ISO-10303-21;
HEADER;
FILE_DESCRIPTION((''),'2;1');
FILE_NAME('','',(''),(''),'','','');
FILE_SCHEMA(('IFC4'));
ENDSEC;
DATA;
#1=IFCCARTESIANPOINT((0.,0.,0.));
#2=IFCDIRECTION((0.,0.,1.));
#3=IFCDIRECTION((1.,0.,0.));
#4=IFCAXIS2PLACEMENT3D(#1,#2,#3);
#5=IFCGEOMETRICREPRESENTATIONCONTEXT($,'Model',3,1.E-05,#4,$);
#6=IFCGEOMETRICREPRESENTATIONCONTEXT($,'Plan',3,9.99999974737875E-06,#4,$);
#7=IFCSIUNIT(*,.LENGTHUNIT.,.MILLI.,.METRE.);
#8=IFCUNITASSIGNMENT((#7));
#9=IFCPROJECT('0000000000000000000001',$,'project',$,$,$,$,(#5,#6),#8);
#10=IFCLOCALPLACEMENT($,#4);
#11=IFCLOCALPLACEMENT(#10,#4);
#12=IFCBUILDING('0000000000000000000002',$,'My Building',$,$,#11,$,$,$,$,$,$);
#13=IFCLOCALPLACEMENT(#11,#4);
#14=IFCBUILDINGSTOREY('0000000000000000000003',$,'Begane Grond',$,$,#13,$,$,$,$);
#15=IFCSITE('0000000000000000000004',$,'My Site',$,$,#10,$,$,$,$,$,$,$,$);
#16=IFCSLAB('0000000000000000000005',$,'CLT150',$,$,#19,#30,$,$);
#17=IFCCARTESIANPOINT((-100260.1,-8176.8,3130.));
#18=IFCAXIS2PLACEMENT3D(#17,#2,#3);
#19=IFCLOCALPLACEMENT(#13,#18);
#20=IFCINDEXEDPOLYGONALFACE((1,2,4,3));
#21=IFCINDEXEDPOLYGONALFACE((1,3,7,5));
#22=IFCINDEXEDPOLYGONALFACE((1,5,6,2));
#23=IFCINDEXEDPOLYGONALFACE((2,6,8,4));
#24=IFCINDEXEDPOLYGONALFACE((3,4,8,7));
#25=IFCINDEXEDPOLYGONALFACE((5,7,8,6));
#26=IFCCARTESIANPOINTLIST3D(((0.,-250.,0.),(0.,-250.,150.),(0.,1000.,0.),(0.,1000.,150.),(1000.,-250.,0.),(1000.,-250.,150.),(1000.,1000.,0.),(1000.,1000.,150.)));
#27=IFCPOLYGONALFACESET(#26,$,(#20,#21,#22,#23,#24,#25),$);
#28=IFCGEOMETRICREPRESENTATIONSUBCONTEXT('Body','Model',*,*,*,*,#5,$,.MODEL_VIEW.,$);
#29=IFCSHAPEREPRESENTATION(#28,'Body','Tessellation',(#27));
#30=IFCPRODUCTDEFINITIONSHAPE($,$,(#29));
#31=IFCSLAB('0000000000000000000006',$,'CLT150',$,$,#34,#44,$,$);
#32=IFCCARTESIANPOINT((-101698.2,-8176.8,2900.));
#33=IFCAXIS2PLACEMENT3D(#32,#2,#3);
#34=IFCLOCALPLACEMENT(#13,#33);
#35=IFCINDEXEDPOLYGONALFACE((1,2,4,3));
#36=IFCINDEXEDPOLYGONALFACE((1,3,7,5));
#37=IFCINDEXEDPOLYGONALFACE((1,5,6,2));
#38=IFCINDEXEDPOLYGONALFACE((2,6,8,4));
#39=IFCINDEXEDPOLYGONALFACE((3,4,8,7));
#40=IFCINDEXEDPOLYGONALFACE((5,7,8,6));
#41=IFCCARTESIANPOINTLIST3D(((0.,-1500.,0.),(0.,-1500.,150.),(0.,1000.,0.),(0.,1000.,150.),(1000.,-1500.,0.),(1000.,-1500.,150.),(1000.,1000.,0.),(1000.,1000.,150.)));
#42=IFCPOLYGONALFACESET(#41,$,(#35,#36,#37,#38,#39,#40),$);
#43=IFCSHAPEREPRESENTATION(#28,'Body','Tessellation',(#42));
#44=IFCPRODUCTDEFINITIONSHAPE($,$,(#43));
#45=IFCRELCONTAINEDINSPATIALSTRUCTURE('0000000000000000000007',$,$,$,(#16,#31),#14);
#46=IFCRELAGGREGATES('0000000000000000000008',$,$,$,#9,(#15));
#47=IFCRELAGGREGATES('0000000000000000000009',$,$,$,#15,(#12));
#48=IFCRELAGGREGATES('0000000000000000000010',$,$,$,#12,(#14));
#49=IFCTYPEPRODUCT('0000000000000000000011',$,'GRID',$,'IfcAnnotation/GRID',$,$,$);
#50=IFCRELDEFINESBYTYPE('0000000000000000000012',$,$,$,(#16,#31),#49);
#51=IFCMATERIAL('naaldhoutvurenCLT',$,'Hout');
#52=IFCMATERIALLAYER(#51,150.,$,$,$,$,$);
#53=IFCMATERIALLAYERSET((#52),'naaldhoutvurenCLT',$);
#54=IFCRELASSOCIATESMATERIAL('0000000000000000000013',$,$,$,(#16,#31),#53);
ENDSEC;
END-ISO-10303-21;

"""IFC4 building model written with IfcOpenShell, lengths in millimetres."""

from ifc_helpers import new_model, si_unit, frame, origin_with_axes, place, context, subcontext, project, spatial, line, indexed_curve, outline, extrude, material, layer, layer_set, layer_usage, type_object, element, save


model = new_model("IFC4")

# Units and contexts
model_context = context("Model", 3, precision=1e-05, world=origin_with_axes())
plan_context = context("Plan", 3, precision=9.99999974737875e-06, world=origin_with_axes())
body_context = subcontext(model_context, "Body", "Model", "MODEL_VIEW")
ifc_project = project(units=[si_unit("LENGTHUNIT", "METRE", prefix="MILLI")], contexts=[model_context, plan_context])

# Site, building, storey
site_placement = place(None, frame((0.0, 0.0, 0.0), z_axis=(0.0, 0.0, 1.0), x_axis=(1.0, 0.0, 0.0)))
site = spatial("IfcSite", under=ifc_project, at=site_placement, Name="My Site")
building_placement = place(site_placement, origin_with_axes())
building = spatial("IfcBuilding", under=site, at=building_placement, Name="My Building")
storey_placement = place(building_placement, origin_with_axes())
storey = spatial("IfcBuildingStorey", under=building, at=storey_placement, Name="Begane Grond")

# Shared definitions
type_product = type_object("IfcTypeProduct", Name="GRID", ApplicableOccurrence="IfcAnnotation/GRID")

# Slabs
ifc_material_1 = material(Name="naaldhoutvurenCLT", Category="Hout")
ifc_layer_1 = layer(ifc_material_1, 150.0)
ifc_layer_set_1 = layer_set([ifc_layer_1], Name="naaldhoutvurenCLT")
ifc_layer_usage_1 = layer_usage(ifc_layer_set_1, "AXIS3", "POSITIVE", 0.0)
slab_1_placement = place(storey_placement, frame((-100260.1, -8176.8, 3130.0), z_axis=(0.0, 0.0, 1.0), x_axis=(1.0, 0.0, 0.0)))
element("IfcSlab", 1, at=slab_1_placement, inside=storey, type_object=type_product, material=ifc_layer_usage_1, Name="CLT150", context=body_context, shape_type="SweptSolid", body=[
    extrude(outline(indexed_curve([(1000.0, 1000.0), (1000.0, -250.0), (0.0, -250.0), (0.0, 1000.0)], segments=[line(4, 1), line(1, 2), line(2, 3), line(3, 4)], self_intersect=False)), None, (0.0, 0.0, 1.0), 150.0),
])
ifc_layer_usage_2 = layer_usage(ifc_layer_set_1, "AXIS3", "POSITIVE", 0.0)
slab_2_placement = place(storey_placement, frame((-101698.2, -8176.8, 2900.0), z_axis=(0.0, 0.0, 1.0), x_axis=(1.0, 0.0, 0.0)))
element("IfcSlab", 2, at=slab_2_placement, inside=storey, type_object=type_product, material=ifc_layer_usage_2, Name="CLT150", context=body_context, shape_type="SweptSolid", body=[
    extrude(outline(indexed_curve([(0.0, -1500.0), (1000.0, -1500.0), (1000.0, 1000.0), (0.0, 1000.0)], segments=[line(3, 2), line(2, 1), line(1, 4), line(4, 3)], self_intersect=False)), None, (0.0, 0.0, 1.0), 150.0),
])

save(model, "model.ifc")
